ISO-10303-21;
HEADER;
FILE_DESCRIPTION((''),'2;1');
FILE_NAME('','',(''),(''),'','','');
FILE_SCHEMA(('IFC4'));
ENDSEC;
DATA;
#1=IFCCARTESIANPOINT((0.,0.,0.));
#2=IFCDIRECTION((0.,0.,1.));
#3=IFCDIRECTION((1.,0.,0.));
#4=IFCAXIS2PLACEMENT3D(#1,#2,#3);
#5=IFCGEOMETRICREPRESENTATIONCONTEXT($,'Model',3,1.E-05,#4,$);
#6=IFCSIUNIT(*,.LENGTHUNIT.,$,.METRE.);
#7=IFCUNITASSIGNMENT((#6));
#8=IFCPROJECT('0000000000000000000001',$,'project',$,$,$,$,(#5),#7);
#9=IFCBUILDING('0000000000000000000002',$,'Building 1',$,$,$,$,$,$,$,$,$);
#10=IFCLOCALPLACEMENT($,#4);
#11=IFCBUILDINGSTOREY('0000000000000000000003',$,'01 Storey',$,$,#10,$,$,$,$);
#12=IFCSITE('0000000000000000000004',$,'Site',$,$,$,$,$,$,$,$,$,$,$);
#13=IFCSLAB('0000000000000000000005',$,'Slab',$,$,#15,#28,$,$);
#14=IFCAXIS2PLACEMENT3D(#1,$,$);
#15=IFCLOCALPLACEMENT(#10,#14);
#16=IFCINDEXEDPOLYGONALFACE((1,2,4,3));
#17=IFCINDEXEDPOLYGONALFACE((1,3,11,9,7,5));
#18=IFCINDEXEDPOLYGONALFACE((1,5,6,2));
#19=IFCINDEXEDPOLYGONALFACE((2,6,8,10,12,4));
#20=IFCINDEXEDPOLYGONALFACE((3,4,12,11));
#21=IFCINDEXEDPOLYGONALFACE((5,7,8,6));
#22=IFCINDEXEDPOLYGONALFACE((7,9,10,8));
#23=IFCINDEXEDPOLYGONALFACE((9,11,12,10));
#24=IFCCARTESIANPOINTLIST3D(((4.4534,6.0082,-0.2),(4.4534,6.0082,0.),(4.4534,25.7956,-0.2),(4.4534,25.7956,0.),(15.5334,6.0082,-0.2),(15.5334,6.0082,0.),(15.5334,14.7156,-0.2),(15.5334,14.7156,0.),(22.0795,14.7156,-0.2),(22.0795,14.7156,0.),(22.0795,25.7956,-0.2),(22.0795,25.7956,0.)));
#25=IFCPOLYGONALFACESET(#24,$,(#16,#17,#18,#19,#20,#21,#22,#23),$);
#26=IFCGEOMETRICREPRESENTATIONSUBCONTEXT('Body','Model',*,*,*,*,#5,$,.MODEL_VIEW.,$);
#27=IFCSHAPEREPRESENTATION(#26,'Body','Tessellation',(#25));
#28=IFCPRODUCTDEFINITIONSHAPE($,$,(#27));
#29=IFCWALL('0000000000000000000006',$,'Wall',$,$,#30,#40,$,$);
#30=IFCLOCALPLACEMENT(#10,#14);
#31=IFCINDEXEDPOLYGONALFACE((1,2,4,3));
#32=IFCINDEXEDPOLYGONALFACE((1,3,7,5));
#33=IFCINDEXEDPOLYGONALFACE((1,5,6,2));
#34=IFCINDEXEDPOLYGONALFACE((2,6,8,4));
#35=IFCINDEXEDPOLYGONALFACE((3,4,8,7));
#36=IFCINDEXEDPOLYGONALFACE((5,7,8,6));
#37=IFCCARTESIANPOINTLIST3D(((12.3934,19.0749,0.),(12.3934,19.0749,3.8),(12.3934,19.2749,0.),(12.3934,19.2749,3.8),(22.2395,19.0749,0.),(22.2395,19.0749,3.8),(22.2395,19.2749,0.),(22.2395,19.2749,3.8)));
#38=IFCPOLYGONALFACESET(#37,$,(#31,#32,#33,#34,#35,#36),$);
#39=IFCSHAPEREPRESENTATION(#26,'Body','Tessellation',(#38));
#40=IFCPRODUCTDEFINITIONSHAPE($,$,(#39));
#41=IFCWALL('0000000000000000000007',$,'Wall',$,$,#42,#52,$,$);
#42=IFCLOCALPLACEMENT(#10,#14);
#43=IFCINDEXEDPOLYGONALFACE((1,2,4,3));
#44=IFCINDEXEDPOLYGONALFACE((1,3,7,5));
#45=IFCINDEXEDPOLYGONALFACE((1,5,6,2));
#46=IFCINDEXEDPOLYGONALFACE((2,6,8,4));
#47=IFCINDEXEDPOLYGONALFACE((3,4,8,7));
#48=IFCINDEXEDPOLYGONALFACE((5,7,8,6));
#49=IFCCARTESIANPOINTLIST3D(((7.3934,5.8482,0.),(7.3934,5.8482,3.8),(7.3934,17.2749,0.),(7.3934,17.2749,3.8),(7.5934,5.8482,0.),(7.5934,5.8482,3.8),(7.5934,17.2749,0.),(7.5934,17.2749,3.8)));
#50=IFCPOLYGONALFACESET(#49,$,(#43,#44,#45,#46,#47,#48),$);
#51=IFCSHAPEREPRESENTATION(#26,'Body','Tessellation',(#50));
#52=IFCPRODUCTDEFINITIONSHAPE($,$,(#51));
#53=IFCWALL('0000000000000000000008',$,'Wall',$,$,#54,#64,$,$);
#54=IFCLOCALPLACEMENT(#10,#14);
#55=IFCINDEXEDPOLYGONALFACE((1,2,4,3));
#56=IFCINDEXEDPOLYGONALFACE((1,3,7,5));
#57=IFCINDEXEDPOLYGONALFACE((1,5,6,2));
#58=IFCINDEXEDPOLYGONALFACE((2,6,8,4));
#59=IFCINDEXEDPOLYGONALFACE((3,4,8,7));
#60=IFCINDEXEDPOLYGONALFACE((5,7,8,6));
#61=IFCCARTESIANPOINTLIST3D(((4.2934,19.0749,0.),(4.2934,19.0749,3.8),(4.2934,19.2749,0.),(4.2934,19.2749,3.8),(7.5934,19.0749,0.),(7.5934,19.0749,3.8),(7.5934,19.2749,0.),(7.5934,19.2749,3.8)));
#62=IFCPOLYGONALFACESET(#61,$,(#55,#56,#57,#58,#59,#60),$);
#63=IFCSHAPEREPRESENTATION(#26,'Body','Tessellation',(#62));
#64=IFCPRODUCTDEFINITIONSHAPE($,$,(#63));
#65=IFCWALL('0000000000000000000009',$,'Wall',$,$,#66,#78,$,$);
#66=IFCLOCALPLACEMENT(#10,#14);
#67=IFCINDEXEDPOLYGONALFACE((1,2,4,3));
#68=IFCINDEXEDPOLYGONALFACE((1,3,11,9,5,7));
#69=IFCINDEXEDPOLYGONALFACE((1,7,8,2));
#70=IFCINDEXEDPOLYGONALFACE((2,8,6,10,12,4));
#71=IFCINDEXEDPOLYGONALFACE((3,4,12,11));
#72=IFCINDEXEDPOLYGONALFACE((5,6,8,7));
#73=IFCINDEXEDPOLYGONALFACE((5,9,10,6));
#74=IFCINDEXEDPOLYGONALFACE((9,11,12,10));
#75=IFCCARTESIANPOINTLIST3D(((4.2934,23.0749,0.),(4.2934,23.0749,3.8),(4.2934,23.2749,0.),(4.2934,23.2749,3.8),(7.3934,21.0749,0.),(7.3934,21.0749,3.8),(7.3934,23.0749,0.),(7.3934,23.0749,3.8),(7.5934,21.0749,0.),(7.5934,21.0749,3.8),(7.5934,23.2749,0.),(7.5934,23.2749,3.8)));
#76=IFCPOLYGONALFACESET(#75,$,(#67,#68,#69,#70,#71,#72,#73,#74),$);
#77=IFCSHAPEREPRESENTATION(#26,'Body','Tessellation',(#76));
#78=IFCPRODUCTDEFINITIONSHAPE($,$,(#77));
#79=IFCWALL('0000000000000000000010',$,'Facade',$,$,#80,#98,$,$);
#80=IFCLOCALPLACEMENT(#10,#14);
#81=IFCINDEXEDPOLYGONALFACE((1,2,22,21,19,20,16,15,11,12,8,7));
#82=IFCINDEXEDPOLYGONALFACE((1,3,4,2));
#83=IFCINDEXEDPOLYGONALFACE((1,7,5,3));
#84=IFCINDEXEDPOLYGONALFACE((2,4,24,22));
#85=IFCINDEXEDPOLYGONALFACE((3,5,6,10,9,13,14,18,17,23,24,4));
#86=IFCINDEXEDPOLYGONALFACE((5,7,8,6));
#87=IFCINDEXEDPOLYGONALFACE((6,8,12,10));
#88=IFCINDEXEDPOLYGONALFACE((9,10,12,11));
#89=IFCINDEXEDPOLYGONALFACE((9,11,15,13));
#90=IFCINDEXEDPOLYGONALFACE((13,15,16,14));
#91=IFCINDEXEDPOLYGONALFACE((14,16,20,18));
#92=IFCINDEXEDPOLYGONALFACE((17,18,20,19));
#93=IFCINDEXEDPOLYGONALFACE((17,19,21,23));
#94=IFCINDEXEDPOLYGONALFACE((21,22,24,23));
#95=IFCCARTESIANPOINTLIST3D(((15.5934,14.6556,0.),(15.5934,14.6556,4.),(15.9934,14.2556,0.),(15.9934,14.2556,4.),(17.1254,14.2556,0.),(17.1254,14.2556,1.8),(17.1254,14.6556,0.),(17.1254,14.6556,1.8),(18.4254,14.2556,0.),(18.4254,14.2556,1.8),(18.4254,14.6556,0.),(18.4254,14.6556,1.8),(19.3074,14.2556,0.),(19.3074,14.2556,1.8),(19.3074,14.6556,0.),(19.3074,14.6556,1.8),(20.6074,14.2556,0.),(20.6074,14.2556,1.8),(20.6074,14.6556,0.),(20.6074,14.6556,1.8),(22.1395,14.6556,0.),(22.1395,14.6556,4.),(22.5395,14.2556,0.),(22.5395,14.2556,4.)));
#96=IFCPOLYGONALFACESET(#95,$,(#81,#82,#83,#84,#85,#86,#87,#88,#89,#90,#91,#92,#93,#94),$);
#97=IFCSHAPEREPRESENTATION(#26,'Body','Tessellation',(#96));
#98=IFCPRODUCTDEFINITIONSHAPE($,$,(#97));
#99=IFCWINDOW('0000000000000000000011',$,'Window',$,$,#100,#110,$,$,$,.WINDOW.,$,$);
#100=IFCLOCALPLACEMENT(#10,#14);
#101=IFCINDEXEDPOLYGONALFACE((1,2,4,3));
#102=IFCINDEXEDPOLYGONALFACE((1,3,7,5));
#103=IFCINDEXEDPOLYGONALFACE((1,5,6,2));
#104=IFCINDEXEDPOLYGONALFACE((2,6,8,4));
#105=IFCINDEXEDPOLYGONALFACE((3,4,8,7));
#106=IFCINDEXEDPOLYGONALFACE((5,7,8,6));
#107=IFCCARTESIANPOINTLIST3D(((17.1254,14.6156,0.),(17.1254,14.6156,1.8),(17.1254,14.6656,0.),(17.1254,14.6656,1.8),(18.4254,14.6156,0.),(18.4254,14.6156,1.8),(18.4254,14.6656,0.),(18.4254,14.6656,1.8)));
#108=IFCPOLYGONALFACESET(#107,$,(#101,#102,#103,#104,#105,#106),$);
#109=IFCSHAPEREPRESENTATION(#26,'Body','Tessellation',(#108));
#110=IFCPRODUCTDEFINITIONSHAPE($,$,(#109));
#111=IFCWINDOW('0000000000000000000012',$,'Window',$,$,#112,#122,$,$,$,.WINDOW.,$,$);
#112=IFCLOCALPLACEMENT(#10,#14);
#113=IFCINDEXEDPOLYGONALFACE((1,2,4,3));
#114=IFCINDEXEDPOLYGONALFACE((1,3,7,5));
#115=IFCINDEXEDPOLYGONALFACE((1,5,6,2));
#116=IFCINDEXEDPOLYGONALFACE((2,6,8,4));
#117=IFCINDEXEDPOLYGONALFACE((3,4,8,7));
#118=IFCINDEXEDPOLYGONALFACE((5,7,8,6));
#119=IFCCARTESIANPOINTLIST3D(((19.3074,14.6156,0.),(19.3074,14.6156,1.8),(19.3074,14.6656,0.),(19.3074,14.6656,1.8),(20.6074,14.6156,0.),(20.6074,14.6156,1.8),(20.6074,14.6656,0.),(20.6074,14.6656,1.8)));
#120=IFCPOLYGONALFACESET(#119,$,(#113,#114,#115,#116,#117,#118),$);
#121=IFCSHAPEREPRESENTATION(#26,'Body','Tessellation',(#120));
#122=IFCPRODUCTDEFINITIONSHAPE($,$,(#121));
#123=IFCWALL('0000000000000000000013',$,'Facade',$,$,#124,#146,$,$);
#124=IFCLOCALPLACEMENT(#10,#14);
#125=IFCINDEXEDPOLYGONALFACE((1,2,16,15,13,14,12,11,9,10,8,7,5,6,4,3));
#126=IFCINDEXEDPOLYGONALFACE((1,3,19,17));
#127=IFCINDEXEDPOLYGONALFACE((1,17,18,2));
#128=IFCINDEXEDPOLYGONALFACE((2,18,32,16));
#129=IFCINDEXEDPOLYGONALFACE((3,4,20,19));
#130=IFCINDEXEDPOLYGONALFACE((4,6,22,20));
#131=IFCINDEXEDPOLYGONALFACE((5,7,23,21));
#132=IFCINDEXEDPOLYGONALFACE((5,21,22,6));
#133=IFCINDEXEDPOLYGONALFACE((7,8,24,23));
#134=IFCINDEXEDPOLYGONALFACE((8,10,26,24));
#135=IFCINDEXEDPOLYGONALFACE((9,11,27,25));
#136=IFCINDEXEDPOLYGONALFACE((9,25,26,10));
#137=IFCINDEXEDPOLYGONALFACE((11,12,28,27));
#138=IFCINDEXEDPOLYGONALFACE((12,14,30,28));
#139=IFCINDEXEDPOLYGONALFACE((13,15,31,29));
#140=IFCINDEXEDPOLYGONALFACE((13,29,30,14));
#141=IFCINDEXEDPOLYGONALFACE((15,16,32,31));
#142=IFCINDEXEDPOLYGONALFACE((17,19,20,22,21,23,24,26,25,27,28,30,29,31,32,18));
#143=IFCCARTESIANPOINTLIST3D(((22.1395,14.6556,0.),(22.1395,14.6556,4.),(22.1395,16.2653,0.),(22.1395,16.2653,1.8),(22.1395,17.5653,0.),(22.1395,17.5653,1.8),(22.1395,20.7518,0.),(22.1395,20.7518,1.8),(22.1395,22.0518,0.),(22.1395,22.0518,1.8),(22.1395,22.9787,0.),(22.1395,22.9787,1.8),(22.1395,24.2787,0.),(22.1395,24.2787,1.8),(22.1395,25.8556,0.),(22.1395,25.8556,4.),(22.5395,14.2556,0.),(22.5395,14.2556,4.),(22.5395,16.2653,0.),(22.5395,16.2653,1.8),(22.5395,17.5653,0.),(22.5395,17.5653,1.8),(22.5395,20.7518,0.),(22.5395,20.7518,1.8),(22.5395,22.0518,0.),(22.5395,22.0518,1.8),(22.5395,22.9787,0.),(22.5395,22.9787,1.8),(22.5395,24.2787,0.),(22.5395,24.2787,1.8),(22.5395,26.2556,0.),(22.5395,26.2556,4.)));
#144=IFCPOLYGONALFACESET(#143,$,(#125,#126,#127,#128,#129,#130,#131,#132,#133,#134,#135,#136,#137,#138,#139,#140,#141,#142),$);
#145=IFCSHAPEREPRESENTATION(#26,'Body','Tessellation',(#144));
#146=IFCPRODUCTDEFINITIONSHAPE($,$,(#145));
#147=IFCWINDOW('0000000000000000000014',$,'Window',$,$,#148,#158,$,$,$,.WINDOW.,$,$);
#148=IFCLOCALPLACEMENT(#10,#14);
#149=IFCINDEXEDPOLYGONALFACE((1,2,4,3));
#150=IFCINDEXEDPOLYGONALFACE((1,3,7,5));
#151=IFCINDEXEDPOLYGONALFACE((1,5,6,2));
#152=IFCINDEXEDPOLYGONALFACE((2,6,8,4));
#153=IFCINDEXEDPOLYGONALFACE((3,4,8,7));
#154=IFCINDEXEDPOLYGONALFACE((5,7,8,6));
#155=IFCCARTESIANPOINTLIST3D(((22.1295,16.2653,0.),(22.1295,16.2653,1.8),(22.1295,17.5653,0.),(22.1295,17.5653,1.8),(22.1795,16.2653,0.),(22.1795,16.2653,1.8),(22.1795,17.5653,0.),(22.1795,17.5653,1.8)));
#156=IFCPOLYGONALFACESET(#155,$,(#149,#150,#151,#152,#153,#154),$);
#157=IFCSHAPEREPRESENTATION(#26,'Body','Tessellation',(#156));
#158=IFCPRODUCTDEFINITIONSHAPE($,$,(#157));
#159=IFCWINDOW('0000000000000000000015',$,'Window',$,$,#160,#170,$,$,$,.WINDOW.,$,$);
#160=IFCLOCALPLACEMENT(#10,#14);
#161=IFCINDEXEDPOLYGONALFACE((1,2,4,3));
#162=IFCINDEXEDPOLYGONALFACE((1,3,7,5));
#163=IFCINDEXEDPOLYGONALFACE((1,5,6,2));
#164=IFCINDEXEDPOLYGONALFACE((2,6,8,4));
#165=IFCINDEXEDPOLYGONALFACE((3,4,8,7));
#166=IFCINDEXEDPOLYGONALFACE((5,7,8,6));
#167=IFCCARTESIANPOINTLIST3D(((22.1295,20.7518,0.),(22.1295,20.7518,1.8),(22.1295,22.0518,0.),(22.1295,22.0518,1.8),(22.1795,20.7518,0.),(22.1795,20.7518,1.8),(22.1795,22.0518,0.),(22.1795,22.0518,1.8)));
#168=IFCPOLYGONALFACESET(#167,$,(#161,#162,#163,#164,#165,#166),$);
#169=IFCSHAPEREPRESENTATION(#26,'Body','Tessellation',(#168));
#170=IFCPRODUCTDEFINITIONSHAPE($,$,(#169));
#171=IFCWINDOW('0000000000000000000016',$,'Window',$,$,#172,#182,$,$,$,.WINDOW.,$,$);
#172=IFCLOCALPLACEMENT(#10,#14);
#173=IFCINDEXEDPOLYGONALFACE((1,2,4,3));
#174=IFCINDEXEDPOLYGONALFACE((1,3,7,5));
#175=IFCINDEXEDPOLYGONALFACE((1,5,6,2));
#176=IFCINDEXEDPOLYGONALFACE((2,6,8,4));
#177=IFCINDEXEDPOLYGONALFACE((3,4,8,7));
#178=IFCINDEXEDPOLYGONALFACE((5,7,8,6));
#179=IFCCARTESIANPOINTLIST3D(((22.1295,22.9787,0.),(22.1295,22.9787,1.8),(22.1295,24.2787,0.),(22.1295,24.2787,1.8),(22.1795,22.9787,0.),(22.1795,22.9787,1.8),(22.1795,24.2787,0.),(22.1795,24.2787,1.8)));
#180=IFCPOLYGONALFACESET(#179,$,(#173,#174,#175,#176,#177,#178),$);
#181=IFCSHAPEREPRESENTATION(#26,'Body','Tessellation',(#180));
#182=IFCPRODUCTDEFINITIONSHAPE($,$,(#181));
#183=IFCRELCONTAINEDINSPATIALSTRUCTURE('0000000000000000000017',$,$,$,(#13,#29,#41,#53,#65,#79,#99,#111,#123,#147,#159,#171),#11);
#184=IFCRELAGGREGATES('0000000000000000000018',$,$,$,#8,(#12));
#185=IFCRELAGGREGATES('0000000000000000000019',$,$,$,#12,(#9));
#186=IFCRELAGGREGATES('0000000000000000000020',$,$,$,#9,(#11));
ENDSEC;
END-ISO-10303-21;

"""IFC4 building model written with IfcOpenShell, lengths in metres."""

from ifc_helpers import new_model, si_unit, origin_with_axes, place, context, subcontext, project, spatial, line, indexed_curve, outline, extrude, element, fill, save


model = new_model("IFC4")

# Units and contexts
model_context = context("Model", 3, precision=1e-05, world=origin_with_axes())
body_context = subcontext(model_context, "Body", "Model", "MODEL_VIEW")
ifc_project = project(units=[si_unit("LENGTHUNIT", "METRE")], contexts=[model_context])

# Site, building, storey
site = spatial("IfcSite", under=ifc_project, Name="Site")
building = spatial("IfcBuilding", under=site, Name="Building 1")
storey_placement = place(None, origin_with_axes())
storey = spatial("IfcBuildingStorey", under=building, at=storey_placement, Name="01 Storey")

# Slab
slab_placement = place(storey_placement, origin_with_axes())
element("IfcSlab", 1, at=slab_placement, inside=storey, Name="Slab", context=body_context, shape_type="SweptSolid", body=[
    extrude(outline(indexed_curve([(15.5334, 14.7156), (22.0795, 14.7156), (22.0795, 25.7956), (4.4534, 25.7956), (4.4534, 6.0082), (15.5334, 6.0082)], segments=[line(1, 2), line(2, 3), line(3, 4), line(4, 5), line(5, 6)])), origin_with_axes(), (0.0, 0.0, -1.0), 0.2),
])

# Walls
wall_1_placement = place(storey_placement, origin_with_axes())
element("IfcWall", 2, at=wall_1_placement, inside=storey, Name="Wall", context=body_context, shape_type="SweptSolid", body=[
    extrude(outline(indexed_curve([(22.2395, 19.2749), (12.3934, 19.2749), (12.3934, 19.0749), (22.2395, 19.0749)], segments=[line(1, 2), line(2, 3), line(3, 4)])), origin_with_axes(), (0.0, 0.0, 1.0), 3.8),
])
wall_2_placement = place(storey_placement, origin_with_axes())
element("IfcWall", 3, at=wall_2_placement, inside=storey, Name="Wall", context=body_context, shape_type="SweptSolid", body=[
    extrude(outline(indexed_curve([(7.5934, 17.2749), (7.3934, 17.2749), (7.3934, 5.8482), (7.5934, 5.8482)], segments=[line(1, 2), line(2, 3), line(3, 4)])), origin_with_axes(), (0.0, 0.0, 1.0), 3.8),
])
wall_3_placement = place(storey_placement, origin_with_axes())
element("IfcWall", 4, at=wall_3_placement, inside=storey, Name="Wall", context=body_context, shape_type="SweptSolid", body=[
    extrude(outline(indexed_curve([(7.5934, 19.2749), (4.2934, 19.2749), (4.2934, 19.0749), (7.5934, 19.0749)], segments=[line(1, 2), line(2, 3), line(3, 4)])), origin_with_axes(), (0.0, 0.0, 1.0), 3.8),
])
wall_4_placement = place(storey_placement, origin_with_axes())
element("IfcWall", 5, at=wall_4_placement, inside=storey, Name="Wall", context=body_context, shape_type="SweptSolid", body=[
    extrude(outline(indexed_curve([(7.5934, 23.2749), (4.2934, 23.2749), (4.2934, 23.0749), (7.3934, 23.0749), (7.3934, 21.0749), (7.5934, 21.0749)], segments=[line(1, 2), line(2, 3), line(3, 4), line(4, 5), line(5, 6)])), origin_with_axes(), (0.0, 0.0, 1.0), 3.8),
])

# Walls, openings, windows
wall_5_placement = place(storey_placement, origin_with_axes())
wall_5 = element("IfcWall", 6, at=wall_5_placement, inside=storey, Name="Facade", context=body_context, shape_type="SweptSolid", body=[
    extrude(outline(indexed_curve([(15.5934, 14.6556), (22.1395, 14.6556), (22.5395, 14.2556), (15.9934, 14.2556)], segments=[line(1, 2), line(2, 3), line(3, 4)])), origin_with_axes(), (0.0, 0.0, 1.0), 4.0),
])
opening_1_placement = place(wall_5_placement, origin_with_axes())
opening_1 = element("IfcOpeningElement", 7, at=opening_1_placement, cuts=wall_5, context=body_context, shape_type="SweptSolid", body=[
    extrude(outline(indexed_curve([(17.1254, 14.2156), (17.1254, 14.7156), (18.4254, 14.7156), (18.4254, 14.2156)], segments=[line(1, 2), line(2, 3), line(3, 4)])), origin_with_axes(), (0.0, 0.0, 1.0), 1.8),
])
opening_2_placement = place(wall_5_placement, origin_with_axes())
opening_2 = element("IfcOpeningElement", 8, at=opening_2_placement, cuts=wall_5, context=body_context, shape_type="SweptSolid", body=[
    extrude(outline(indexed_curve([(19.3074, 14.2156), (19.3074, 14.7156), (20.6074, 14.7156), (20.6074, 14.2156)], segments=[line(1, 2), line(2, 3), line(3, 4)])), origin_with_axes(), (0.0, 0.0, 1.0), 1.8),
])
window_1_placement = place(storey_placement, origin_with_axes())
window_1 = element("IfcWindow", 9, at=window_1_placement, inside=storey, Name="Window", PredefinedType="WINDOW", context=body_context, shape_type="SweptSolid", body=[
    extrude(outline(indexed_curve([(17.1254, 14.6156), (17.1254, 14.6656), (18.4254, 14.6656), (18.4254, 14.6156)], segments=[line(1, 2), line(2, 3), line(3, 4)])), origin_with_axes(), (0.0, 0.0, 1.0), 1.8),
])
fill(opening_1, window_1)
window_2_placement = place(storey_placement, origin_with_axes())
window_2 = element("IfcWindow", 10, at=window_2_placement, inside=storey, Name="Window", PredefinedType="WINDOW", context=body_context, shape_type="SweptSolid", body=[
    extrude(outline(indexed_curve([(19.3074, 14.6156), (19.3074, 14.6656), (20.6074, 14.6656), (20.6074, 14.6156)], segments=[line(1, 2), line(2, 3), line(3, 4)])), origin_with_axes(), (0.0, 0.0, 1.0), 1.8),
])
fill(opening_2, window_2)
wall_6_placement = place(storey_placement, origin_with_axes())
wall_6 = element("IfcWall", 11, at=wall_6_placement, inside=storey, Name="Facade", context=body_context, shape_type="SweptSolid", body=[
    extrude(outline(indexed_curve([(22.1395, 14.6556), (22.1395, 25.8556), (22.5395, 26.2556), (22.5395, 14.2556)], segments=[line(1, 2), line(2, 3), line(3, 4)])), origin_with_axes(), (0.0, 0.0, 1.0), 4.0),
])
opening_3_placement = place(wall_6_placement, origin_with_axes())
opening_3 = element("IfcOpeningElement", 12, at=opening_3_placement, cuts=wall_6, context=body_context, shape_type="SweptSolid", body=[
    extrude(outline(indexed_curve([(22.5795, 16.2653), (22.0795, 16.2653), (22.0795, 17.5653), (22.5795, 17.5653)], segments=[line(1, 2), line(2, 3), line(3, 4)])), origin_with_axes(), (0.0, 0.0, 1.0), 1.8),
])
opening_4_placement = place(wall_6_placement, origin_with_axes())
opening_4 = element("IfcOpeningElement", 13, at=opening_4_placement, cuts=wall_6, context=body_context, shape_type="SweptSolid", body=[
    extrude(outline(indexed_curve([(22.5795, 20.7518), (22.0795, 20.7518), (22.0795, 22.0518), (22.5795, 22.0518)], segments=[line(1, 2), line(2, 3), line(3, 4)])), origin_with_axes(), (0.0, 0.0, 1.0), 1.8),
])
opening_5_placement = place(wall_6_placement, origin_with_axes())
opening_5 = element("IfcOpeningElement", 14, at=opening_5_placement, cuts=wall_6, context=body_context, shape_type="SweptSolid", body=[
    extrude(outline(indexed_curve([(22.5795, 22.9787), (22.0795, 22.9787), (22.0795, 24.2787), (22.5795, 24.2787)], segments=[line(1, 2), line(2, 3), line(3, 4)])), origin_with_axes(), (0.0, 0.0, 1.0), 1.8),
])
window_3_placement = place(storey_placement, origin_with_axes())
window_3 = element("IfcWindow", 15, at=window_3_placement, inside=storey, Name="Window", PredefinedType="WINDOW", context=body_context, shape_type="SweptSolid", body=[
    extrude(outline(indexed_curve([(22.1795, 16.2653), (22.1295, 16.2653), (22.1295, 17.5653), (22.1795, 17.5653)], segments=[line(1, 2), line(2, 3), line(3, 4)])), origin_with_axes(), (0.0, 0.0, 1.0), 1.8),
])
fill(opening_3, window_3)
window_4_placement = place(storey_placement, origin_with_axes())
window_4 = element("IfcWindow", 16, at=window_4_placement, inside=storey, Name="Window", PredefinedType="WINDOW", context=body_context, shape_type="SweptSolid", body=[
    extrude(outline(indexed_curve([(22.1795, 20.7518), (22.1295, 20.7518), (22.1295, 22.0518), (22.1795, 22.0518)], segments=[line(1, 2), line(2, 3), line(3, 4)])), origin_with_axes(), (0.0, 0.0, 1.0), 1.8),
])
fill(opening_4, window_4)
window_5_placement = place(storey_placement, origin_with_axes())
window_5 = element("IfcWindow", 17, at=window_5_placement, inside=storey, Name="Window", PredefinedType="WINDOW", context=body_context, shape_type="SweptSolid", body=[
    extrude(outline(indexed_curve([(22.1795, 22.9787), (22.1295, 22.9787), (22.1295, 24.2787), (22.1795, 24.2787)], segments=[line(1, 2), line(2, 3), line(3, 4)])), origin_with_axes(), (0.0, 0.0, 1.0), 1.8),
])
fill(opening_5, window_5)

save(model, "model.ifc")
